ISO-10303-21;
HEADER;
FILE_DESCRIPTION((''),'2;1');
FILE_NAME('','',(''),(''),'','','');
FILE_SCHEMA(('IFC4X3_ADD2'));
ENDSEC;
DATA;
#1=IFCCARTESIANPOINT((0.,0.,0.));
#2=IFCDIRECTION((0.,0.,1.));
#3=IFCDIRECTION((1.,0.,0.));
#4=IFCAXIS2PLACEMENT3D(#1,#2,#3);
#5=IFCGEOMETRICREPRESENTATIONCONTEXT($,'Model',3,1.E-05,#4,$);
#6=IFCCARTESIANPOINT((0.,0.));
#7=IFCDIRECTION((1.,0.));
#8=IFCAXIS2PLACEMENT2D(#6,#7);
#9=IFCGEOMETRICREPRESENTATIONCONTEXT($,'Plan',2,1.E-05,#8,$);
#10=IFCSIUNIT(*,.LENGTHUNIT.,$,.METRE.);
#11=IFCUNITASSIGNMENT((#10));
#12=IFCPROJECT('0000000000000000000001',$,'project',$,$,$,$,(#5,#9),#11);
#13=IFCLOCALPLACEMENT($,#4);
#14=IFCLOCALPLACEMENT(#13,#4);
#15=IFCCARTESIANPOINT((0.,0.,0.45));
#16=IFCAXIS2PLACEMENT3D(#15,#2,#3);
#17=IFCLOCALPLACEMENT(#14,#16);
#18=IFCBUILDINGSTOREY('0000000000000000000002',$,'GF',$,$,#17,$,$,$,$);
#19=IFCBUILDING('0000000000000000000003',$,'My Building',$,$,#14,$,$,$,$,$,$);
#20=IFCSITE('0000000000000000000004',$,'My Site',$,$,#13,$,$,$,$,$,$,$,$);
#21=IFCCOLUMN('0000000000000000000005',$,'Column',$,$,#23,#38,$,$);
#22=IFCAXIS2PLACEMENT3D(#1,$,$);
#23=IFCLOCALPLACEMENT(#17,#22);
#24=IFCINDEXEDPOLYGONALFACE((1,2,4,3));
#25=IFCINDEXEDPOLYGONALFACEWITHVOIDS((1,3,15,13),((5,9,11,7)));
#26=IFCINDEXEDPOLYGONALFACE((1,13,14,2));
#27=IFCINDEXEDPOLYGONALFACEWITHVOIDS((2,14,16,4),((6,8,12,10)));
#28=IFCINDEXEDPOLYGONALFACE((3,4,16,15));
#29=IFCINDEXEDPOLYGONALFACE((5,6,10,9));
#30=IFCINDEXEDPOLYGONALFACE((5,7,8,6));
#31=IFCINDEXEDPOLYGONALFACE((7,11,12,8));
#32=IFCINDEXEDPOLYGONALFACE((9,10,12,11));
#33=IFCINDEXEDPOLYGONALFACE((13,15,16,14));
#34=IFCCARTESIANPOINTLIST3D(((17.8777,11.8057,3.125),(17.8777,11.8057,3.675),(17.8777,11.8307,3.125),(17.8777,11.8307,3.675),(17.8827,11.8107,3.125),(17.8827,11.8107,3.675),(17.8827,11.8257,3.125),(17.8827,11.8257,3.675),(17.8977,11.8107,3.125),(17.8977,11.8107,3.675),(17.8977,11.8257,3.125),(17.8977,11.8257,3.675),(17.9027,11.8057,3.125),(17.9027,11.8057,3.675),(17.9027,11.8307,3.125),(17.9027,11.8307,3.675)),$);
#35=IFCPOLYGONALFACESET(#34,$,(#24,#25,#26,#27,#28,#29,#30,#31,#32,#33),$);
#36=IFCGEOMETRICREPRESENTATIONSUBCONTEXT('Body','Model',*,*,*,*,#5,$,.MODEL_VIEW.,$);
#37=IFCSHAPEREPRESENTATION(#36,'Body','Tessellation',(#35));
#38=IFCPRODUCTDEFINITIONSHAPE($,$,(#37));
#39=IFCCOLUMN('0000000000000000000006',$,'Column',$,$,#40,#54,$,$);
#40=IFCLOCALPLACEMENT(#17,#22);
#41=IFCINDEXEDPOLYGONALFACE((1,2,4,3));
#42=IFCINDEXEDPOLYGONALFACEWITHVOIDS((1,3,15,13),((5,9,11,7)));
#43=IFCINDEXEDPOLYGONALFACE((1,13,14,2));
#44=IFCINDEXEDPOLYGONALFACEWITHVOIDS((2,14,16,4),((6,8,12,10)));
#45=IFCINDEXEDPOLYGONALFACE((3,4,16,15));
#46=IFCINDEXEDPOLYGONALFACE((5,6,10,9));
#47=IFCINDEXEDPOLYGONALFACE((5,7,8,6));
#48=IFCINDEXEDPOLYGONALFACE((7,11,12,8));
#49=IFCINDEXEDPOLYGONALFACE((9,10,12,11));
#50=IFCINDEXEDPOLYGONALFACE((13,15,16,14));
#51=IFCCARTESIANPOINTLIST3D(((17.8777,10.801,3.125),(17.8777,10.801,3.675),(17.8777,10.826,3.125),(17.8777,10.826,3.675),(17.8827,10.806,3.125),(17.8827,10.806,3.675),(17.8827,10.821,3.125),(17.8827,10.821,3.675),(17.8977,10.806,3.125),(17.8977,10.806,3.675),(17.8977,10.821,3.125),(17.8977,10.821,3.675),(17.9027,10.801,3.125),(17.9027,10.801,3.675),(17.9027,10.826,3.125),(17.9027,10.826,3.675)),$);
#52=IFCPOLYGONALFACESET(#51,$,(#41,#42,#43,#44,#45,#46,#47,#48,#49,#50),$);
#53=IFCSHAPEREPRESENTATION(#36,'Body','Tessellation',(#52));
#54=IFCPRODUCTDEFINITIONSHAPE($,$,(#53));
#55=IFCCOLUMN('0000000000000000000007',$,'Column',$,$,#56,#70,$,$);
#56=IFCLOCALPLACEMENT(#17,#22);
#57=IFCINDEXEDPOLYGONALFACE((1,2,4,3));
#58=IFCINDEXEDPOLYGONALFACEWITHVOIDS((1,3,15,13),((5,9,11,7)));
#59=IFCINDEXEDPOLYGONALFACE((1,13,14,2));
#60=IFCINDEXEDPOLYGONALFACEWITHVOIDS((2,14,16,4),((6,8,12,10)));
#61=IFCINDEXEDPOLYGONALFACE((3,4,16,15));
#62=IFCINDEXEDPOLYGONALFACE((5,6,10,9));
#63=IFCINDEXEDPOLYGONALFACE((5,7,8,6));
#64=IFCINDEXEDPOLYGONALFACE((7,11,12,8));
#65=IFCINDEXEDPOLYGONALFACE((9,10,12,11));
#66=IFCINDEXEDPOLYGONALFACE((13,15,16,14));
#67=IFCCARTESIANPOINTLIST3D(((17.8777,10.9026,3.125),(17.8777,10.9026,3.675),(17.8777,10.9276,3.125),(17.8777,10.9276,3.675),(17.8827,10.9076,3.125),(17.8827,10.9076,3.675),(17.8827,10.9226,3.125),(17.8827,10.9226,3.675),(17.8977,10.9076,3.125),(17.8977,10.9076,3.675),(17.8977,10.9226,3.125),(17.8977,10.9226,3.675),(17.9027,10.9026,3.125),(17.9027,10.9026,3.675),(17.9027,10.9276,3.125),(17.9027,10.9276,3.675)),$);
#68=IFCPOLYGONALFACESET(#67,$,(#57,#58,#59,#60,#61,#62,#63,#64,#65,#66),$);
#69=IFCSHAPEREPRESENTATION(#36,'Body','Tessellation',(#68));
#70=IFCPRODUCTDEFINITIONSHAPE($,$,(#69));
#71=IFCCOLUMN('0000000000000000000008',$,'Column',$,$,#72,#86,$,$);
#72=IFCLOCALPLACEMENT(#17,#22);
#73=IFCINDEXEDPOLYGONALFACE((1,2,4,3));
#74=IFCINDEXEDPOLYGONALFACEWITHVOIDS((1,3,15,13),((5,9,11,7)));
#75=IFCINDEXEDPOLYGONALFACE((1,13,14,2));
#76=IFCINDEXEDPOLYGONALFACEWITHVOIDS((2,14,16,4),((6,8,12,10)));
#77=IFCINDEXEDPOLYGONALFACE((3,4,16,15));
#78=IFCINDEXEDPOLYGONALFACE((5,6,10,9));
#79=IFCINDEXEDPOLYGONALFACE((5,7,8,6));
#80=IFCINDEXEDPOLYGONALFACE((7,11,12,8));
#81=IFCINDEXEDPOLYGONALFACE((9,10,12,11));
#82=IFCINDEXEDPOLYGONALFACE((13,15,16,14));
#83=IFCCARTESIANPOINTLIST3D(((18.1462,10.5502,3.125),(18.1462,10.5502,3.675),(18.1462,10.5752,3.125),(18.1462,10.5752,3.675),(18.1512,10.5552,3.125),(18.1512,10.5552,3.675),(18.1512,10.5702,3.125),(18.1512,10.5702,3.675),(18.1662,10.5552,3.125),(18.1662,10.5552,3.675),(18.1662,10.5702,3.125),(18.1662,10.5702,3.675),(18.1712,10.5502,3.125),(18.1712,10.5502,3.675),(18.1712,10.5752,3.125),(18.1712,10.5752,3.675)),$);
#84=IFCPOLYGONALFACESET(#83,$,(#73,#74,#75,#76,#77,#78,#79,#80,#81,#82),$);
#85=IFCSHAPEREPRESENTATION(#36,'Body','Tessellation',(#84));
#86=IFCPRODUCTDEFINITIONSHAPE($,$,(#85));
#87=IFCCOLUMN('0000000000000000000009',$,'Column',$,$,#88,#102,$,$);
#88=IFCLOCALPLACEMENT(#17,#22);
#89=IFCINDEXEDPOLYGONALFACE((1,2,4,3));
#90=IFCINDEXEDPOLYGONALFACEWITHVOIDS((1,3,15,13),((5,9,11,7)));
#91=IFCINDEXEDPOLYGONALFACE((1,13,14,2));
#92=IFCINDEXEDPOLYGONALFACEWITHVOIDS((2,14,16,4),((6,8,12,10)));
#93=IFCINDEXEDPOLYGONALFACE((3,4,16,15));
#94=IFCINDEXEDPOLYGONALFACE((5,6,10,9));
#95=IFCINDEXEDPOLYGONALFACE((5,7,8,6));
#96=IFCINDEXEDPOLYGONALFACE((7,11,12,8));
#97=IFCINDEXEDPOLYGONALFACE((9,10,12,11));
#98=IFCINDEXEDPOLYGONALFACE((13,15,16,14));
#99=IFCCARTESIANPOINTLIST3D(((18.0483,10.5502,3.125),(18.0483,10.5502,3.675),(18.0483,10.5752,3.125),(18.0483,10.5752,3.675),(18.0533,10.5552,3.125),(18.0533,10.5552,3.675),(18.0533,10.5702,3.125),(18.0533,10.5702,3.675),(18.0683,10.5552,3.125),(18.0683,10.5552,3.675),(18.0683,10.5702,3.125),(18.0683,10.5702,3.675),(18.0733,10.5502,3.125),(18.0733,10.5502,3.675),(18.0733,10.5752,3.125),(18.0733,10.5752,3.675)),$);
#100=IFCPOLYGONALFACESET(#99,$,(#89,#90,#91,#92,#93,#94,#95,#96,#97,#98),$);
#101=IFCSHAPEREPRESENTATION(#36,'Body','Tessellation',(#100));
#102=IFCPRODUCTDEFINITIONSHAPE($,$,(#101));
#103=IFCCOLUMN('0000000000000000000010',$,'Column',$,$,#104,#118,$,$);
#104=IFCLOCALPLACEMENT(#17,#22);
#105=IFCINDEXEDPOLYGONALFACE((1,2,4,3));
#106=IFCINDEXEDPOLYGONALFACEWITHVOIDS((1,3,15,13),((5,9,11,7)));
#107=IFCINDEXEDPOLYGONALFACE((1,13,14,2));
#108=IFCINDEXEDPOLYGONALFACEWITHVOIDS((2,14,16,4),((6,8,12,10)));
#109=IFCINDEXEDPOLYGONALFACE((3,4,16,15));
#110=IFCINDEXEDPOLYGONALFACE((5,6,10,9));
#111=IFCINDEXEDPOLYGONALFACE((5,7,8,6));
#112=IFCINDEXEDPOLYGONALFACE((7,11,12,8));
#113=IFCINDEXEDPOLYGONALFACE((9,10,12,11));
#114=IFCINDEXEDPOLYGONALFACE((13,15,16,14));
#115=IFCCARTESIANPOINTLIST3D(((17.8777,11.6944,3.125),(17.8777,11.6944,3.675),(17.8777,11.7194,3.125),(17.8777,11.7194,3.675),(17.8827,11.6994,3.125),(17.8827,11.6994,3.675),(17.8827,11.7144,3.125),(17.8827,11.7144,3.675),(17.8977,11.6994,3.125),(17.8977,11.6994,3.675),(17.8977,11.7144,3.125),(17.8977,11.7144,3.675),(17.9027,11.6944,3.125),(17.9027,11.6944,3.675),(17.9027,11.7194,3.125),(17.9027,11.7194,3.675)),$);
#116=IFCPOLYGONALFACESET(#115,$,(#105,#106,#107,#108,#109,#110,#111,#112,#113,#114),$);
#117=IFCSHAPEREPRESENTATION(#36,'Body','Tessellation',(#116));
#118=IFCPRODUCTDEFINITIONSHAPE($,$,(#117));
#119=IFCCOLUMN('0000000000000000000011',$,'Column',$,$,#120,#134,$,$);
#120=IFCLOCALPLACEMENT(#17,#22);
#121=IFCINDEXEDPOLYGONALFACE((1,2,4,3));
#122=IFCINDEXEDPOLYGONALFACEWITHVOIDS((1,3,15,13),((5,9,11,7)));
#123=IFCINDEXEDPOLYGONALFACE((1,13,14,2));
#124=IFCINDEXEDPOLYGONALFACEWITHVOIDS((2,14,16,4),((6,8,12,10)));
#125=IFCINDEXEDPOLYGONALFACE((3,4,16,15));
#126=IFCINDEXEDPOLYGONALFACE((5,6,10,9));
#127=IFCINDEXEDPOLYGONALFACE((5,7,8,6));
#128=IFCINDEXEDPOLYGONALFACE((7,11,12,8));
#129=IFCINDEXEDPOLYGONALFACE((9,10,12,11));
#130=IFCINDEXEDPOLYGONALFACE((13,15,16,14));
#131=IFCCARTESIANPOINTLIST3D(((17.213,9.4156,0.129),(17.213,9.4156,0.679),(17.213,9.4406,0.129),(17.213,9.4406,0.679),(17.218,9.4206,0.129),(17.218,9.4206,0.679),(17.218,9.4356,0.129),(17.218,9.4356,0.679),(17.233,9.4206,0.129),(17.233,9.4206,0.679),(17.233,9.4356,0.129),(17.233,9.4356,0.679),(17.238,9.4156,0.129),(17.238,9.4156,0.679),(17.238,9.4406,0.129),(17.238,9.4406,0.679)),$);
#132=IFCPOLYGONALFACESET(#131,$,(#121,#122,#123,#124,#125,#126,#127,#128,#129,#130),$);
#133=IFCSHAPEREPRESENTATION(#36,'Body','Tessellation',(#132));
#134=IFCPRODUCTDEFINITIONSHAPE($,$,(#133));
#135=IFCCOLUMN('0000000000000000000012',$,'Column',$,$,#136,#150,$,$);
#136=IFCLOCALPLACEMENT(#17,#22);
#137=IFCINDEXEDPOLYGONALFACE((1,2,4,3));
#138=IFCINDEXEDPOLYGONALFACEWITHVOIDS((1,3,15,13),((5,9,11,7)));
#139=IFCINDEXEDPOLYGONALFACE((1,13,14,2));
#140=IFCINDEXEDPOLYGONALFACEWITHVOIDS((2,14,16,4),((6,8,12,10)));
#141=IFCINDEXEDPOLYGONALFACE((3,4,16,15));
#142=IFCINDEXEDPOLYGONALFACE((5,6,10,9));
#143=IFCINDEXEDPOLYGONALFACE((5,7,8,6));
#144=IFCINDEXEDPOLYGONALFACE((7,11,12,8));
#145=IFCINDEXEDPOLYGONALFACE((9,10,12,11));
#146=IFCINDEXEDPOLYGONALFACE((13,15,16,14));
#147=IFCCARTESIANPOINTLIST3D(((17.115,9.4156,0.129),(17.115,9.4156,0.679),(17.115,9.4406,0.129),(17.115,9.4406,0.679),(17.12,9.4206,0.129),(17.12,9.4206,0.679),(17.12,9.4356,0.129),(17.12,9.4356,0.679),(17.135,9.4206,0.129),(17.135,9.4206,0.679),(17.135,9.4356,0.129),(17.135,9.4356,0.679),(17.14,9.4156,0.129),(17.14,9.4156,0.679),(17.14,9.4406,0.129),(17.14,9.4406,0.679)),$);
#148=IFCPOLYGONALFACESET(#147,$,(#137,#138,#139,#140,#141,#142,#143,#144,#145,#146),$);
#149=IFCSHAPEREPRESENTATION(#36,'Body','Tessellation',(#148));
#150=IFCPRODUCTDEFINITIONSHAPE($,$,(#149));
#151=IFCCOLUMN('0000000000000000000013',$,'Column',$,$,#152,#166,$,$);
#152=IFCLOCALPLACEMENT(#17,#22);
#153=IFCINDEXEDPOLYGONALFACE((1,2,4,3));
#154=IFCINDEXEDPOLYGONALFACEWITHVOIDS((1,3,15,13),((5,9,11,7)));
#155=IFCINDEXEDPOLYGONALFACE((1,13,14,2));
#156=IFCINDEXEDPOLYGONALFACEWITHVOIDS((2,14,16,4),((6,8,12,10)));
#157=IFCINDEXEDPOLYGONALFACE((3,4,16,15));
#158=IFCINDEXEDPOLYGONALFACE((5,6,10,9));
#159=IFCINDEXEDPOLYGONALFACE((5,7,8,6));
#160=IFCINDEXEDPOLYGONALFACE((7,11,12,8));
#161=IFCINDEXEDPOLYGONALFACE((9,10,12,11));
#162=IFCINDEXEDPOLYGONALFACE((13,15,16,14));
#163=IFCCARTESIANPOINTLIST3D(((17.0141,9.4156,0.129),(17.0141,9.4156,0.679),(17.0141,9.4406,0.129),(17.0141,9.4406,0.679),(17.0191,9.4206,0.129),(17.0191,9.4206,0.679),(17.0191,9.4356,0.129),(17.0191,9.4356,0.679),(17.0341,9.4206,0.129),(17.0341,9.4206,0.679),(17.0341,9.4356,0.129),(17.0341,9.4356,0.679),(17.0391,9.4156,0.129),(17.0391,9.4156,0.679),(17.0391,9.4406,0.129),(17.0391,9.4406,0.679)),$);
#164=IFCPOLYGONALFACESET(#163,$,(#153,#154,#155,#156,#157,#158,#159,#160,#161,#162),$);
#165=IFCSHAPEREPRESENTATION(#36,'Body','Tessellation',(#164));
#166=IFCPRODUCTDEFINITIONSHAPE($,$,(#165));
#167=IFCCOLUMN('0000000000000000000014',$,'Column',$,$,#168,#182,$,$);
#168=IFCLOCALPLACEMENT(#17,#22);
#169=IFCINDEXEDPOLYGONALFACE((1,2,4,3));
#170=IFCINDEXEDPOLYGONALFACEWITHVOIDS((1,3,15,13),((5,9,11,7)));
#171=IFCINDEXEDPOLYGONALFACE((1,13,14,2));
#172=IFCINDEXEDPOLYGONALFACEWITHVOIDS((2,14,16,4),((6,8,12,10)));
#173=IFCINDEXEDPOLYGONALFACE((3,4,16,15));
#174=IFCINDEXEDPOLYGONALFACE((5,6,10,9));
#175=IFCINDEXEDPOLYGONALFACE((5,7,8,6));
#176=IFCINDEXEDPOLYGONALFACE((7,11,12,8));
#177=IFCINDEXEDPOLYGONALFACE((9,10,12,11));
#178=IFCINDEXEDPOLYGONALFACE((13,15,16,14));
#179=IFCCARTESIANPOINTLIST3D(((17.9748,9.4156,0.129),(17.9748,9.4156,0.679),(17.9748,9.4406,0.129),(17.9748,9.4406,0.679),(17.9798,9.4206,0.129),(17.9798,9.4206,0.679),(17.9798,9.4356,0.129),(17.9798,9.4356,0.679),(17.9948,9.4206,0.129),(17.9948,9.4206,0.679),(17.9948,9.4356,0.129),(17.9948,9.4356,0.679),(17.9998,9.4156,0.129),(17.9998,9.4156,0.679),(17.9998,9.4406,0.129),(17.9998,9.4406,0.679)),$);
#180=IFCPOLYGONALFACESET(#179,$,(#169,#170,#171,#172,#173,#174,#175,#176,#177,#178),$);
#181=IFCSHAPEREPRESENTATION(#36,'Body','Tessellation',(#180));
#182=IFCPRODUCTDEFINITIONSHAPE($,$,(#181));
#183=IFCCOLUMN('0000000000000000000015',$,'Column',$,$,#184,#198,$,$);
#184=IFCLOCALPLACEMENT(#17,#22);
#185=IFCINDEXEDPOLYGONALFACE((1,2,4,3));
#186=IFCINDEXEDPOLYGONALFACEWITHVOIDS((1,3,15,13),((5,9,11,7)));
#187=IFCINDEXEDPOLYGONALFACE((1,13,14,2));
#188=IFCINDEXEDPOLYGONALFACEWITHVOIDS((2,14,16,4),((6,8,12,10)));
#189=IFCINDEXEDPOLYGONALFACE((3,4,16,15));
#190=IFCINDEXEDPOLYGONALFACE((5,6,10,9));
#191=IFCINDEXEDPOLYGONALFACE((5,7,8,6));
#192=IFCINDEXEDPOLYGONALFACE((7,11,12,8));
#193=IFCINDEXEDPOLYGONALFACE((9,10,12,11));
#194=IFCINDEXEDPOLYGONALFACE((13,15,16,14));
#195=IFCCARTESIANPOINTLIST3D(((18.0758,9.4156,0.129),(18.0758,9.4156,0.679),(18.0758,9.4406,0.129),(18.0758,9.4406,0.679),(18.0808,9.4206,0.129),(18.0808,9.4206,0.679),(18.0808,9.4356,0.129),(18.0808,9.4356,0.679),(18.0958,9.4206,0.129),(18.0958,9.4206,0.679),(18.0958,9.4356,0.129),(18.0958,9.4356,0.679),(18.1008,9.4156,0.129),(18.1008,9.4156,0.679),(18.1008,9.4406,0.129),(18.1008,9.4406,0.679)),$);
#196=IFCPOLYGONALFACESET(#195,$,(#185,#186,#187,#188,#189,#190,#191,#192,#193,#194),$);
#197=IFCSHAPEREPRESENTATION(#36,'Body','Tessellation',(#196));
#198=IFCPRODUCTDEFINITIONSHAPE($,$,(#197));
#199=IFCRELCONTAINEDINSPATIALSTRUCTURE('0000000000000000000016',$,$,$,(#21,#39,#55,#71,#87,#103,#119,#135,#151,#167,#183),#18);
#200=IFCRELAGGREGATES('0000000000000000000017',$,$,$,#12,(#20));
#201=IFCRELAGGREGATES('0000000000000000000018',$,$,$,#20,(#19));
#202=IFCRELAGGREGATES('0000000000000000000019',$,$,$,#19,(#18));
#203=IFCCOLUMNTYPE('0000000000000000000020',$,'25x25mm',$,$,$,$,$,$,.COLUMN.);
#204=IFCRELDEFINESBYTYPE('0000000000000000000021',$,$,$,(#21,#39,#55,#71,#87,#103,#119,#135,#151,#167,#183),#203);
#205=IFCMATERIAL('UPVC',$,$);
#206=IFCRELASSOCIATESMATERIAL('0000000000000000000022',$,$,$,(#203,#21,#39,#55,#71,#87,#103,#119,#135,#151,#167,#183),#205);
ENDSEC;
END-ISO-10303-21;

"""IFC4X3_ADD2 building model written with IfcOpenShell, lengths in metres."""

from ifc_helpers import new_model, si_unit, frame, origin_with_axes, origin_2d_with_axis, place, context, subcontext, project, spatial, hollow_rectangle, extrude, material, material_profile, profile_set, profile_usage, type_object, element, save


model = new_model("IFC4X3_ADD2")

# Units and contexts
model_context = context("Model", 3, precision=1e-05, world=origin_with_axes())
plan_context = context("Plan", 2, precision=1e-05, world=origin_2d_with_axis())
body_context_1 = subcontext(model_context, "Body", "Model", "MODEL_VIEW")
ifc_project = project(units=[si_unit("LENGTHUNIT", "METRE")], contexts=[model_context, plan_context])

# Site, building, storey
site_placement = place(None, origin_with_axes())
site = spatial("IfcSite", under=ifc_project, at=site_placement, Name="My Site")
building_placement = place(site_placement, origin_with_axes())
building = spatial("IfcBuilding", under=site, at=building_placement, Name="My Building")
storey_placement = place(building_placement, frame((0.0, 0.0, 0.45), z_axis=(0.0, 0.0, 1.0), x_axis=(1.0, 0.0, 0.0)))
storey = spatial("IfcBuildingStorey", under=building, at=storey_placement, Name="GF")

# Columns
ifc_material_1 = material(Name="UPVC")
ifc_material_profile_1 = material_profile(ifc_material_1, hollow_rectangle(XDim=0.025, YDim=0.025, WallThickness=0.005))
ifc_profile_set_1 = profile_set([ifc_material_profile_1])
ifc_profile_usage_1 = profile_usage(ifc_profile_set_1)
column_type_1 = type_object("IfcColumnType", Name="25x25mm", PredefinedType="COLUMN", material=ifc_profile_set_1)
column_1_placement = place(storey_placement, frame((17.8902, 11.8182, 3.125), z_axis=(0.0, 0.0, 1.0), x_axis=(0.0, -1.0, 0.0)))
element("IfcColumn", 1, at=column_1_placement, inside=storey, type_object=column_type_1, material=ifc_profile_usage_1, Name="Column", context=body_context_1, shape_type="SweptSolid", body=[
    extrude(hollow_rectangle(XDim=0.025, YDim=0.025, WallThickness=0.005), origin_with_axes(), (0.0, 0.0, 1.0), 0.55),
])
ifc_profile_usage_2 = profile_usage(ifc_profile_set_1)
column_2_placement = place(storey_placement, frame((17.8902, 10.8135, 3.125), z_axis=(0.0, 0.0, 1.0), x_axis=(0.0, -1.0, 0.0)))
element("IfcColumn", 2, at=column_2_placement, inside=storey, type_object=column_type_1, material=ifc_profile_usage_2, Name="Column", context=body_context_1, shape_type="SweptSolid", body=[
    extrude(hollow_rectangle(XDim=0.025, YDim=0.025, WallThickness=0.005), origin_with_axes(), (0.0, 0.0, 1.0), 0.55),
])
ifc_profile_usage_3 = profile_usage(ifc_profile_set_1)
column_3_placement = place(storey_placement, frame((17.8902, 10.9151, 3.125), z_axis=(0.0, 0.0, 1.0), x_axis=(0.0, -1.0, 0.0)))
element("IfcColumn", 3, at=column_3_placement, inside=storey, type_object=column_type_1, material=ifc_profile_usage_3, Name="Column", context=body_context_1, shape_type="SweptSolid", body=[
    extrude(hollow_rectangle(XDim=0.025, YDim=0.025, WallThickness=0.005), origin_with_axes(), (0.0, 0.0, 1.0), 0.55),
])
ifc_profile_usage_4 = profile_usage(ifc_profile_set_1)
column_4_placement = place(storey_placement, frame((18.1587, 10.5627, 3.125), z_axis=(0.0, 0.0, 1.0), x_axis=(0.0, -1.0, 0.0)))
element("IfcColumn", 4, at=column_4_placement, inside=storey, type_object=column_type_1, material=ifc_profile_usage_4, Name="Column", context=body_context_1, shape_type="SweptSolid", body=[
    extrude(hollow_rectangle(XDim=0.025, YDim=0.025, WallThickness=0.005), origin_with_axes(), (0.0, 0.0, 1.0), 0.55),
])
ifc_profile_usage_5 = profile_usage(ifc_profile_set_1)
column_5_placement = place(storey_placement, frame((18.0608, 10.5627, 3.125), z_axis=(0.0, 0.0, 1.0), x_axis=(0.0, -1.0, 0.0)))
element("IfcColumn", 5, at=column_5_placement, inside=storey, type_object=column_type_1, material=ifc_profile_usage_5, Name="Column", context=body_context_1, shape_type="SweptSolid", body=[
    extrude(hollow_rectangle(XDim=0.025, YDim=0.025, WallThickness=0.005), origin_with_axes(), (0.0, 0.0, 1.0), 0.55),
])
ifc_profile_usage_6 = profile_usage(ifc_profile_set_1)
column_6_placement = place(storey_placement, frame((17.8902, 11.7069, 3.125), z_axis=(0.0, 0.0, 1.0), x_axis=(0.0, -1.0, 0.0)))
element("IfcColumn", 6, at=column_6_placement, inside=storey, type_object=column_type_1, material=ifc_profile_usage_6, Name="Column", context=body_context_1, shape_type="SweptSolid", body=[
    extrude(hollow_rectangle(XDim=0.025, YDim=0.025, WallThickness=0.005), origin_with_axes(), (0.0, 0.0, 1.0), 0.55),
])
ifc_profile_usage_7 = profile_usage(ifc_profile_set_1)
column_7_placement = place(storey_placement, frame((17.2255, 9.4281, 0.129), z_axis=(0.0, 0.0, 1.0), x_axis=(0.0, -1.0, 0.0)))
element("IfcColumn", 7, at=column_7_placement, inside=storey, type_object=column_type_1, material=ifc_profile_usage_7, Name="Column", context=body_context_1, shape_type="SweptSolid", body=[
    extrude(hollow_rectangle(XDim=0.025, YDim=0.025, WallThickness=0.005), origin_with_axes(), (0.0, 0.0, 1.0), 0.55),
])
ifc_profile_usage_8 = profile_usage(ifc_profile_set_1)
column_8_placement = place(storey_placement, frame((17.1275, 9.4281, 0.129), z_axis=(0.0, 0.0, 1.0), x_axis=(0.0, -1.0, 0.0)))
element("IfcColumn", 8, at=column_8_placement, inside=storey, type_object=column_type_1, material=ifc_profile_usage_8, Name="Column", context=body_context_1, shape_type="SweptSolid", body=[
    extrude(hollow_rectangle(XDim=0.025, YDim=0.025, WallThickness=0.005), origin_with_axes(), (0.0, 0.0, 1.0), 0.55),
])
ifc_profile_usage_9 = profile_usage(ifc_profile_set_1)
column_9_placement = place(storey_placement, frame((17.0266, 9.4281, 0.129), z_axis=(0.0, 0.0, 1.0), x_axis=(0.0, -1.0, 0.0)))
element("IfcColumn", 9, at=column_9_placement, inside=storey, type_object=column_type_1, material=ifc_profile_usage_9, Name="Column", context=body_context_1, shape_type="SweptSolid", body=[
    extrude(hollow_rectangle(XDim=0.025, YDim=0.025, WallThickness=0.005), origin_with_axes(), (0.0, 0.0, 1.0), 0.55),
])
ifc_profile_usage_10 = profile_usage(ifc_profile_set_1)
column_10_placement = place(storey_placement, frame((17.9873, 9.4281, 0.129), z_axis=(0.0, 0.0, 1.0), x_axis=(0.0, -1.0, 0.0)))
element("IfcColumn", 10, at=column_10_placement, inside=storey, type_object=column_type_1, material=ifc_profile_usage_10, Name="Column", context=body_context_1, shape_type="SweptSolid", body=[
    extrude(hollow_rectangle(XDim=0.025, YDim=0.025, WallThickness=0.005), origin_with_axes(), (0.0, 0.0, 1.0), 0.55),
])
ifc_profile_usage_11 = profile_usage(ifc_profile_set_1)
column_11_placement = place(storey_placement, frame((18.0883, 9.4281, 0.129), z_axis=(0.0, 0.0, 1.0), x_axis=(0.0, -1.0, 0.0)))
element("IfcColumn", 11, at=column_11_placement, inside=storey, type_object=column_type_1, material=ifc_profile_usage_11, Name="Column", context=body_context_1, shape_type="SweptSolid", body=[
    extrude(hollow_rectangle(XDim=0.025, YDim=0.025, WallThickness=0.005), origin_with_axes(), (0.0, 0.0, 1.0), 0.55),
])

save(model, "model.ifc")
